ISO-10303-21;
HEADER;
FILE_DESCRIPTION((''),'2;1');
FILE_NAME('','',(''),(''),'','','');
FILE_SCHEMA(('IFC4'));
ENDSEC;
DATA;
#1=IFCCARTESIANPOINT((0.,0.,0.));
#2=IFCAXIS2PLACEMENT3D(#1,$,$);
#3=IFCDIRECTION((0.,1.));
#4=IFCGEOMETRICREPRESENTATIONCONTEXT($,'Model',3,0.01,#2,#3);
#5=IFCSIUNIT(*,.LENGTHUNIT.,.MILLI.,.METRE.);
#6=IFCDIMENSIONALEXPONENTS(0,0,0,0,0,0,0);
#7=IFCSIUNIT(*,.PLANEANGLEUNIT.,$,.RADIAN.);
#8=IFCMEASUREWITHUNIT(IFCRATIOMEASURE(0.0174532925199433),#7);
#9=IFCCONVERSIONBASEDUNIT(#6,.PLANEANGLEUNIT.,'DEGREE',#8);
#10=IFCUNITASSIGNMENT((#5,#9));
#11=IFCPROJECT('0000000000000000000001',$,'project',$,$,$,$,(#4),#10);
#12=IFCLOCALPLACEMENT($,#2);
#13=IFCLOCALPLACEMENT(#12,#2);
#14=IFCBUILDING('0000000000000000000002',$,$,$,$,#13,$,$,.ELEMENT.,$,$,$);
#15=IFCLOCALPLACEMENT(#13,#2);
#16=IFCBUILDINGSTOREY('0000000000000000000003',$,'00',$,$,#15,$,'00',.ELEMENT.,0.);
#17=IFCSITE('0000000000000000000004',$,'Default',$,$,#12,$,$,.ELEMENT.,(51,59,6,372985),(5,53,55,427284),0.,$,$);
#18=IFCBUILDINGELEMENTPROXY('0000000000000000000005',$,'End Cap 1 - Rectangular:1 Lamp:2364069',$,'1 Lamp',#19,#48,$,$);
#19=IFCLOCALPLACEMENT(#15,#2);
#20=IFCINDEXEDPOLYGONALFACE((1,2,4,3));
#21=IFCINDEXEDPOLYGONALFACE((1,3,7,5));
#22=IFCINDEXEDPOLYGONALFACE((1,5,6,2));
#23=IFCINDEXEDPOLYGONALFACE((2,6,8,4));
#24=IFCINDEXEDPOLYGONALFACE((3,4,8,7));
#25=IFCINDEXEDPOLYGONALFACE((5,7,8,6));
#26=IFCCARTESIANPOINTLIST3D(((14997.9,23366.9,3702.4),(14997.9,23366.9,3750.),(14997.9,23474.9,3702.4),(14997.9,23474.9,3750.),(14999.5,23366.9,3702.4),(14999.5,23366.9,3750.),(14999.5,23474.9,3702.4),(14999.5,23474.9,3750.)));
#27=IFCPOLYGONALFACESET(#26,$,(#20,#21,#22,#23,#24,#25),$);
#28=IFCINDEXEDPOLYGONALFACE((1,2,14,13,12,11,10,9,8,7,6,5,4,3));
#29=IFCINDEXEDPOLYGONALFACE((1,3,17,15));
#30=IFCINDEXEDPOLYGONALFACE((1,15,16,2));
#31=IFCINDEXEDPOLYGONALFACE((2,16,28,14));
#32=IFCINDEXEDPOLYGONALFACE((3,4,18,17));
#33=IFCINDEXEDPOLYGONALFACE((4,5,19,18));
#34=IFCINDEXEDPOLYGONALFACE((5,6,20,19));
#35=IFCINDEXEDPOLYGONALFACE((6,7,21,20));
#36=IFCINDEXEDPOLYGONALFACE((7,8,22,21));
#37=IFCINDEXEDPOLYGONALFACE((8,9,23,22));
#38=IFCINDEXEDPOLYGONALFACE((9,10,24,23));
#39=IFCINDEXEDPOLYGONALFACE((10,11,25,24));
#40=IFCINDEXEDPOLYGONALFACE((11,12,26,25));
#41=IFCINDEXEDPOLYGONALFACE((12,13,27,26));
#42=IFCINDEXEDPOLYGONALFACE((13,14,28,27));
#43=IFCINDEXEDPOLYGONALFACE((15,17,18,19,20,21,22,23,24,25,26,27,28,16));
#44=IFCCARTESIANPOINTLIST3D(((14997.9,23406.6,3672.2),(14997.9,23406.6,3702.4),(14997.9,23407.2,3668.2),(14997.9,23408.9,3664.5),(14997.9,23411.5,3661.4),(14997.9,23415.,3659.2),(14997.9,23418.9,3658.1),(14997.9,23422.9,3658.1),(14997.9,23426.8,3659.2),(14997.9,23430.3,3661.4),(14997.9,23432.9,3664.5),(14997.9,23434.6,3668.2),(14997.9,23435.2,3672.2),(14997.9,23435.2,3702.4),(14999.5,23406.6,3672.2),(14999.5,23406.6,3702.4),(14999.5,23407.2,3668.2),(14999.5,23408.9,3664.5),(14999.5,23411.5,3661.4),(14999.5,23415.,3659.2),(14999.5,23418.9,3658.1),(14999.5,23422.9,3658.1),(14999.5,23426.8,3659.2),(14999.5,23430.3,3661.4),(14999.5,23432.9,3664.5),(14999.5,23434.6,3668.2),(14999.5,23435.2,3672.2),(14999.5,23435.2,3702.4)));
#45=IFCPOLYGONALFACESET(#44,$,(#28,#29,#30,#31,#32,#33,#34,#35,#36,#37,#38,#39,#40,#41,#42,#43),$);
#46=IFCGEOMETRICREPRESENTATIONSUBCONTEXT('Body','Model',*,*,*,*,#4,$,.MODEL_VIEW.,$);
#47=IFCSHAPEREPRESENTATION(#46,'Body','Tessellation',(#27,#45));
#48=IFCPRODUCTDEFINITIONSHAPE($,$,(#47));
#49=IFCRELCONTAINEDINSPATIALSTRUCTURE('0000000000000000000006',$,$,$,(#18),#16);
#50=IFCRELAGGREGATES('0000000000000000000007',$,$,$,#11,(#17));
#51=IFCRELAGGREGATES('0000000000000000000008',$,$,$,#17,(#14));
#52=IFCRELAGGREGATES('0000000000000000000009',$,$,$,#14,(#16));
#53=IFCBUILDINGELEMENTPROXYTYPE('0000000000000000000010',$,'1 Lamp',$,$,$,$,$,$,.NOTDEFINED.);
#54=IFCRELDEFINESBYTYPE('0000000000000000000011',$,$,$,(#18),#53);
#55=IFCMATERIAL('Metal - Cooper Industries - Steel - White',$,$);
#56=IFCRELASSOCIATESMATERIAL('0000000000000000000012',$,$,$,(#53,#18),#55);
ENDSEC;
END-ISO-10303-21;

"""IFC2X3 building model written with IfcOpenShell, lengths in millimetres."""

from ifc_helpers import new_model, entity, si_unit, converted_unit, direction, frame, frame_2d, origin, origin_2d_with_axis, place, context, subcontext, project, spatial, polyline, circle_curve, parameter, trimmed, segment, composite_curve, rectangle, outline, extrude, source, transform, mapped, material, type_object, type_shapes, element, save


model = new_model("IFC2X3")

# Units and contexts
model_context = context("Model", 3, precision=0.01, world=origin(), true_north=direction((0.0, 1.0)))
body_context = subcontext(model_context, "Body", "Model", "MODEL_VIEW")
ifc_project = project(units=[si_unit("LENGTHUNIT", "METRE", prefix="MILLI"), converted_unit("PLANEANGLEUNIT", "DEGREE", entity("IfcRatioMeasure", 0.0174532925199433), si_unit("PLANEANGLEUNIT", "RADIAN"), dimensions=[0, 0, 0, 0, 0, 0, 0])], contexts=[model_context])

# Site, building, storey
site_placement = place(None, origin())
site = spatial("IfcSite", under=ifc_project, at=site_placement, Name="Default", CompositionType="ELEMENT", RefLatitude=(51, 59, 6, 372985), RefLongitude=(5, 53, 55, 427284), RefElevation=0.0)
building_placement = place(site_placement, origin())
building = spatial("IfcBuilding", under=site, at=building_placement, CompositionType="ELEMENT")
storey_placement = place(building_placement, origin())
storey = spatial("IfcBuildingStorey", under=building, at=storey_placement, Name="00", LongName="00", CompositionType="ELEMENT", Elevation=0.0)

# Building element proxy
ifc_material_1 = material(Name="Metal - Cooper Industries - Steel - White")
building_element_proxy_type_1 = type_object("IfcBuildingElementProxyType", Name="1 Lamp", PredefinedType="NOTDEFINED", material=ifc_material_1)
shared_shape_1 = source(origin(), body_context, "Body", "SweptSolid", [
    extrude(rectangle(XDim=108.0, YDim=1.6, at=origin_2d_with_axis()), frame((0.0, 0.0, 0.0), z_axis=(0.0, 0.0, 1.0), x_axis=(-1.0, 0.0, 0.0)), (0.0, 0.0, 1.0), 47.6),
    extrude(outline(composite_curve([segment(polyline([(-15.1, -14.3), (15.1, -14.3)]), True, "CONTINUOUS"), segment(polyline([(15.1, -14.3), (15.1, 14.3)]), True, "CONTINUOUS"), segment(polyline([(15.1, 14.3), (-15.1, 14.3)]), True, "CONTINUOUS"), segment(trimmed(circle_curve(frame_2d((-15.1, 0.0), x_axis=(0.0, -1.0)), 14.3), [parameter(180.0)], [parameter(0.0)], True, "PARAMETER"), True, "CONTINUOUS")], self_intersect=False)), frame((0.0, -0.8, 62.7), z_axis=(0.0, 1.0, 0.0), x_axis=(0.0, 0.0, -1.0)), (0.0, 0.0, 1.0), 1.6),
])
type_shapes(building_element_proxy_type_1, [shared_shape_1])
proxy_1_placement = place(storey_placement, frame((14998.7, 23420.9, 3750.0), z_axis=(0.0, 0.0, -1.0), x_axis=(0.0, -1.0, 0.0)))
element("IfcBuildingElementProxy", 1, at=proxy_1_placement, inside=storey, type_object=building_element_proxy_type_1, material=ifc_material_1, Name="End Cap 1 - Rectangular:1 Lamp:2364069", ObjectType="1 Lamp", context=body_context, shape_type="MappedRepresentation", body=[
    mapped(shared_shape_1, transform((0.0, 0.0, 0.0), scale=1.0)),
])

save(model, "model.ifc")
